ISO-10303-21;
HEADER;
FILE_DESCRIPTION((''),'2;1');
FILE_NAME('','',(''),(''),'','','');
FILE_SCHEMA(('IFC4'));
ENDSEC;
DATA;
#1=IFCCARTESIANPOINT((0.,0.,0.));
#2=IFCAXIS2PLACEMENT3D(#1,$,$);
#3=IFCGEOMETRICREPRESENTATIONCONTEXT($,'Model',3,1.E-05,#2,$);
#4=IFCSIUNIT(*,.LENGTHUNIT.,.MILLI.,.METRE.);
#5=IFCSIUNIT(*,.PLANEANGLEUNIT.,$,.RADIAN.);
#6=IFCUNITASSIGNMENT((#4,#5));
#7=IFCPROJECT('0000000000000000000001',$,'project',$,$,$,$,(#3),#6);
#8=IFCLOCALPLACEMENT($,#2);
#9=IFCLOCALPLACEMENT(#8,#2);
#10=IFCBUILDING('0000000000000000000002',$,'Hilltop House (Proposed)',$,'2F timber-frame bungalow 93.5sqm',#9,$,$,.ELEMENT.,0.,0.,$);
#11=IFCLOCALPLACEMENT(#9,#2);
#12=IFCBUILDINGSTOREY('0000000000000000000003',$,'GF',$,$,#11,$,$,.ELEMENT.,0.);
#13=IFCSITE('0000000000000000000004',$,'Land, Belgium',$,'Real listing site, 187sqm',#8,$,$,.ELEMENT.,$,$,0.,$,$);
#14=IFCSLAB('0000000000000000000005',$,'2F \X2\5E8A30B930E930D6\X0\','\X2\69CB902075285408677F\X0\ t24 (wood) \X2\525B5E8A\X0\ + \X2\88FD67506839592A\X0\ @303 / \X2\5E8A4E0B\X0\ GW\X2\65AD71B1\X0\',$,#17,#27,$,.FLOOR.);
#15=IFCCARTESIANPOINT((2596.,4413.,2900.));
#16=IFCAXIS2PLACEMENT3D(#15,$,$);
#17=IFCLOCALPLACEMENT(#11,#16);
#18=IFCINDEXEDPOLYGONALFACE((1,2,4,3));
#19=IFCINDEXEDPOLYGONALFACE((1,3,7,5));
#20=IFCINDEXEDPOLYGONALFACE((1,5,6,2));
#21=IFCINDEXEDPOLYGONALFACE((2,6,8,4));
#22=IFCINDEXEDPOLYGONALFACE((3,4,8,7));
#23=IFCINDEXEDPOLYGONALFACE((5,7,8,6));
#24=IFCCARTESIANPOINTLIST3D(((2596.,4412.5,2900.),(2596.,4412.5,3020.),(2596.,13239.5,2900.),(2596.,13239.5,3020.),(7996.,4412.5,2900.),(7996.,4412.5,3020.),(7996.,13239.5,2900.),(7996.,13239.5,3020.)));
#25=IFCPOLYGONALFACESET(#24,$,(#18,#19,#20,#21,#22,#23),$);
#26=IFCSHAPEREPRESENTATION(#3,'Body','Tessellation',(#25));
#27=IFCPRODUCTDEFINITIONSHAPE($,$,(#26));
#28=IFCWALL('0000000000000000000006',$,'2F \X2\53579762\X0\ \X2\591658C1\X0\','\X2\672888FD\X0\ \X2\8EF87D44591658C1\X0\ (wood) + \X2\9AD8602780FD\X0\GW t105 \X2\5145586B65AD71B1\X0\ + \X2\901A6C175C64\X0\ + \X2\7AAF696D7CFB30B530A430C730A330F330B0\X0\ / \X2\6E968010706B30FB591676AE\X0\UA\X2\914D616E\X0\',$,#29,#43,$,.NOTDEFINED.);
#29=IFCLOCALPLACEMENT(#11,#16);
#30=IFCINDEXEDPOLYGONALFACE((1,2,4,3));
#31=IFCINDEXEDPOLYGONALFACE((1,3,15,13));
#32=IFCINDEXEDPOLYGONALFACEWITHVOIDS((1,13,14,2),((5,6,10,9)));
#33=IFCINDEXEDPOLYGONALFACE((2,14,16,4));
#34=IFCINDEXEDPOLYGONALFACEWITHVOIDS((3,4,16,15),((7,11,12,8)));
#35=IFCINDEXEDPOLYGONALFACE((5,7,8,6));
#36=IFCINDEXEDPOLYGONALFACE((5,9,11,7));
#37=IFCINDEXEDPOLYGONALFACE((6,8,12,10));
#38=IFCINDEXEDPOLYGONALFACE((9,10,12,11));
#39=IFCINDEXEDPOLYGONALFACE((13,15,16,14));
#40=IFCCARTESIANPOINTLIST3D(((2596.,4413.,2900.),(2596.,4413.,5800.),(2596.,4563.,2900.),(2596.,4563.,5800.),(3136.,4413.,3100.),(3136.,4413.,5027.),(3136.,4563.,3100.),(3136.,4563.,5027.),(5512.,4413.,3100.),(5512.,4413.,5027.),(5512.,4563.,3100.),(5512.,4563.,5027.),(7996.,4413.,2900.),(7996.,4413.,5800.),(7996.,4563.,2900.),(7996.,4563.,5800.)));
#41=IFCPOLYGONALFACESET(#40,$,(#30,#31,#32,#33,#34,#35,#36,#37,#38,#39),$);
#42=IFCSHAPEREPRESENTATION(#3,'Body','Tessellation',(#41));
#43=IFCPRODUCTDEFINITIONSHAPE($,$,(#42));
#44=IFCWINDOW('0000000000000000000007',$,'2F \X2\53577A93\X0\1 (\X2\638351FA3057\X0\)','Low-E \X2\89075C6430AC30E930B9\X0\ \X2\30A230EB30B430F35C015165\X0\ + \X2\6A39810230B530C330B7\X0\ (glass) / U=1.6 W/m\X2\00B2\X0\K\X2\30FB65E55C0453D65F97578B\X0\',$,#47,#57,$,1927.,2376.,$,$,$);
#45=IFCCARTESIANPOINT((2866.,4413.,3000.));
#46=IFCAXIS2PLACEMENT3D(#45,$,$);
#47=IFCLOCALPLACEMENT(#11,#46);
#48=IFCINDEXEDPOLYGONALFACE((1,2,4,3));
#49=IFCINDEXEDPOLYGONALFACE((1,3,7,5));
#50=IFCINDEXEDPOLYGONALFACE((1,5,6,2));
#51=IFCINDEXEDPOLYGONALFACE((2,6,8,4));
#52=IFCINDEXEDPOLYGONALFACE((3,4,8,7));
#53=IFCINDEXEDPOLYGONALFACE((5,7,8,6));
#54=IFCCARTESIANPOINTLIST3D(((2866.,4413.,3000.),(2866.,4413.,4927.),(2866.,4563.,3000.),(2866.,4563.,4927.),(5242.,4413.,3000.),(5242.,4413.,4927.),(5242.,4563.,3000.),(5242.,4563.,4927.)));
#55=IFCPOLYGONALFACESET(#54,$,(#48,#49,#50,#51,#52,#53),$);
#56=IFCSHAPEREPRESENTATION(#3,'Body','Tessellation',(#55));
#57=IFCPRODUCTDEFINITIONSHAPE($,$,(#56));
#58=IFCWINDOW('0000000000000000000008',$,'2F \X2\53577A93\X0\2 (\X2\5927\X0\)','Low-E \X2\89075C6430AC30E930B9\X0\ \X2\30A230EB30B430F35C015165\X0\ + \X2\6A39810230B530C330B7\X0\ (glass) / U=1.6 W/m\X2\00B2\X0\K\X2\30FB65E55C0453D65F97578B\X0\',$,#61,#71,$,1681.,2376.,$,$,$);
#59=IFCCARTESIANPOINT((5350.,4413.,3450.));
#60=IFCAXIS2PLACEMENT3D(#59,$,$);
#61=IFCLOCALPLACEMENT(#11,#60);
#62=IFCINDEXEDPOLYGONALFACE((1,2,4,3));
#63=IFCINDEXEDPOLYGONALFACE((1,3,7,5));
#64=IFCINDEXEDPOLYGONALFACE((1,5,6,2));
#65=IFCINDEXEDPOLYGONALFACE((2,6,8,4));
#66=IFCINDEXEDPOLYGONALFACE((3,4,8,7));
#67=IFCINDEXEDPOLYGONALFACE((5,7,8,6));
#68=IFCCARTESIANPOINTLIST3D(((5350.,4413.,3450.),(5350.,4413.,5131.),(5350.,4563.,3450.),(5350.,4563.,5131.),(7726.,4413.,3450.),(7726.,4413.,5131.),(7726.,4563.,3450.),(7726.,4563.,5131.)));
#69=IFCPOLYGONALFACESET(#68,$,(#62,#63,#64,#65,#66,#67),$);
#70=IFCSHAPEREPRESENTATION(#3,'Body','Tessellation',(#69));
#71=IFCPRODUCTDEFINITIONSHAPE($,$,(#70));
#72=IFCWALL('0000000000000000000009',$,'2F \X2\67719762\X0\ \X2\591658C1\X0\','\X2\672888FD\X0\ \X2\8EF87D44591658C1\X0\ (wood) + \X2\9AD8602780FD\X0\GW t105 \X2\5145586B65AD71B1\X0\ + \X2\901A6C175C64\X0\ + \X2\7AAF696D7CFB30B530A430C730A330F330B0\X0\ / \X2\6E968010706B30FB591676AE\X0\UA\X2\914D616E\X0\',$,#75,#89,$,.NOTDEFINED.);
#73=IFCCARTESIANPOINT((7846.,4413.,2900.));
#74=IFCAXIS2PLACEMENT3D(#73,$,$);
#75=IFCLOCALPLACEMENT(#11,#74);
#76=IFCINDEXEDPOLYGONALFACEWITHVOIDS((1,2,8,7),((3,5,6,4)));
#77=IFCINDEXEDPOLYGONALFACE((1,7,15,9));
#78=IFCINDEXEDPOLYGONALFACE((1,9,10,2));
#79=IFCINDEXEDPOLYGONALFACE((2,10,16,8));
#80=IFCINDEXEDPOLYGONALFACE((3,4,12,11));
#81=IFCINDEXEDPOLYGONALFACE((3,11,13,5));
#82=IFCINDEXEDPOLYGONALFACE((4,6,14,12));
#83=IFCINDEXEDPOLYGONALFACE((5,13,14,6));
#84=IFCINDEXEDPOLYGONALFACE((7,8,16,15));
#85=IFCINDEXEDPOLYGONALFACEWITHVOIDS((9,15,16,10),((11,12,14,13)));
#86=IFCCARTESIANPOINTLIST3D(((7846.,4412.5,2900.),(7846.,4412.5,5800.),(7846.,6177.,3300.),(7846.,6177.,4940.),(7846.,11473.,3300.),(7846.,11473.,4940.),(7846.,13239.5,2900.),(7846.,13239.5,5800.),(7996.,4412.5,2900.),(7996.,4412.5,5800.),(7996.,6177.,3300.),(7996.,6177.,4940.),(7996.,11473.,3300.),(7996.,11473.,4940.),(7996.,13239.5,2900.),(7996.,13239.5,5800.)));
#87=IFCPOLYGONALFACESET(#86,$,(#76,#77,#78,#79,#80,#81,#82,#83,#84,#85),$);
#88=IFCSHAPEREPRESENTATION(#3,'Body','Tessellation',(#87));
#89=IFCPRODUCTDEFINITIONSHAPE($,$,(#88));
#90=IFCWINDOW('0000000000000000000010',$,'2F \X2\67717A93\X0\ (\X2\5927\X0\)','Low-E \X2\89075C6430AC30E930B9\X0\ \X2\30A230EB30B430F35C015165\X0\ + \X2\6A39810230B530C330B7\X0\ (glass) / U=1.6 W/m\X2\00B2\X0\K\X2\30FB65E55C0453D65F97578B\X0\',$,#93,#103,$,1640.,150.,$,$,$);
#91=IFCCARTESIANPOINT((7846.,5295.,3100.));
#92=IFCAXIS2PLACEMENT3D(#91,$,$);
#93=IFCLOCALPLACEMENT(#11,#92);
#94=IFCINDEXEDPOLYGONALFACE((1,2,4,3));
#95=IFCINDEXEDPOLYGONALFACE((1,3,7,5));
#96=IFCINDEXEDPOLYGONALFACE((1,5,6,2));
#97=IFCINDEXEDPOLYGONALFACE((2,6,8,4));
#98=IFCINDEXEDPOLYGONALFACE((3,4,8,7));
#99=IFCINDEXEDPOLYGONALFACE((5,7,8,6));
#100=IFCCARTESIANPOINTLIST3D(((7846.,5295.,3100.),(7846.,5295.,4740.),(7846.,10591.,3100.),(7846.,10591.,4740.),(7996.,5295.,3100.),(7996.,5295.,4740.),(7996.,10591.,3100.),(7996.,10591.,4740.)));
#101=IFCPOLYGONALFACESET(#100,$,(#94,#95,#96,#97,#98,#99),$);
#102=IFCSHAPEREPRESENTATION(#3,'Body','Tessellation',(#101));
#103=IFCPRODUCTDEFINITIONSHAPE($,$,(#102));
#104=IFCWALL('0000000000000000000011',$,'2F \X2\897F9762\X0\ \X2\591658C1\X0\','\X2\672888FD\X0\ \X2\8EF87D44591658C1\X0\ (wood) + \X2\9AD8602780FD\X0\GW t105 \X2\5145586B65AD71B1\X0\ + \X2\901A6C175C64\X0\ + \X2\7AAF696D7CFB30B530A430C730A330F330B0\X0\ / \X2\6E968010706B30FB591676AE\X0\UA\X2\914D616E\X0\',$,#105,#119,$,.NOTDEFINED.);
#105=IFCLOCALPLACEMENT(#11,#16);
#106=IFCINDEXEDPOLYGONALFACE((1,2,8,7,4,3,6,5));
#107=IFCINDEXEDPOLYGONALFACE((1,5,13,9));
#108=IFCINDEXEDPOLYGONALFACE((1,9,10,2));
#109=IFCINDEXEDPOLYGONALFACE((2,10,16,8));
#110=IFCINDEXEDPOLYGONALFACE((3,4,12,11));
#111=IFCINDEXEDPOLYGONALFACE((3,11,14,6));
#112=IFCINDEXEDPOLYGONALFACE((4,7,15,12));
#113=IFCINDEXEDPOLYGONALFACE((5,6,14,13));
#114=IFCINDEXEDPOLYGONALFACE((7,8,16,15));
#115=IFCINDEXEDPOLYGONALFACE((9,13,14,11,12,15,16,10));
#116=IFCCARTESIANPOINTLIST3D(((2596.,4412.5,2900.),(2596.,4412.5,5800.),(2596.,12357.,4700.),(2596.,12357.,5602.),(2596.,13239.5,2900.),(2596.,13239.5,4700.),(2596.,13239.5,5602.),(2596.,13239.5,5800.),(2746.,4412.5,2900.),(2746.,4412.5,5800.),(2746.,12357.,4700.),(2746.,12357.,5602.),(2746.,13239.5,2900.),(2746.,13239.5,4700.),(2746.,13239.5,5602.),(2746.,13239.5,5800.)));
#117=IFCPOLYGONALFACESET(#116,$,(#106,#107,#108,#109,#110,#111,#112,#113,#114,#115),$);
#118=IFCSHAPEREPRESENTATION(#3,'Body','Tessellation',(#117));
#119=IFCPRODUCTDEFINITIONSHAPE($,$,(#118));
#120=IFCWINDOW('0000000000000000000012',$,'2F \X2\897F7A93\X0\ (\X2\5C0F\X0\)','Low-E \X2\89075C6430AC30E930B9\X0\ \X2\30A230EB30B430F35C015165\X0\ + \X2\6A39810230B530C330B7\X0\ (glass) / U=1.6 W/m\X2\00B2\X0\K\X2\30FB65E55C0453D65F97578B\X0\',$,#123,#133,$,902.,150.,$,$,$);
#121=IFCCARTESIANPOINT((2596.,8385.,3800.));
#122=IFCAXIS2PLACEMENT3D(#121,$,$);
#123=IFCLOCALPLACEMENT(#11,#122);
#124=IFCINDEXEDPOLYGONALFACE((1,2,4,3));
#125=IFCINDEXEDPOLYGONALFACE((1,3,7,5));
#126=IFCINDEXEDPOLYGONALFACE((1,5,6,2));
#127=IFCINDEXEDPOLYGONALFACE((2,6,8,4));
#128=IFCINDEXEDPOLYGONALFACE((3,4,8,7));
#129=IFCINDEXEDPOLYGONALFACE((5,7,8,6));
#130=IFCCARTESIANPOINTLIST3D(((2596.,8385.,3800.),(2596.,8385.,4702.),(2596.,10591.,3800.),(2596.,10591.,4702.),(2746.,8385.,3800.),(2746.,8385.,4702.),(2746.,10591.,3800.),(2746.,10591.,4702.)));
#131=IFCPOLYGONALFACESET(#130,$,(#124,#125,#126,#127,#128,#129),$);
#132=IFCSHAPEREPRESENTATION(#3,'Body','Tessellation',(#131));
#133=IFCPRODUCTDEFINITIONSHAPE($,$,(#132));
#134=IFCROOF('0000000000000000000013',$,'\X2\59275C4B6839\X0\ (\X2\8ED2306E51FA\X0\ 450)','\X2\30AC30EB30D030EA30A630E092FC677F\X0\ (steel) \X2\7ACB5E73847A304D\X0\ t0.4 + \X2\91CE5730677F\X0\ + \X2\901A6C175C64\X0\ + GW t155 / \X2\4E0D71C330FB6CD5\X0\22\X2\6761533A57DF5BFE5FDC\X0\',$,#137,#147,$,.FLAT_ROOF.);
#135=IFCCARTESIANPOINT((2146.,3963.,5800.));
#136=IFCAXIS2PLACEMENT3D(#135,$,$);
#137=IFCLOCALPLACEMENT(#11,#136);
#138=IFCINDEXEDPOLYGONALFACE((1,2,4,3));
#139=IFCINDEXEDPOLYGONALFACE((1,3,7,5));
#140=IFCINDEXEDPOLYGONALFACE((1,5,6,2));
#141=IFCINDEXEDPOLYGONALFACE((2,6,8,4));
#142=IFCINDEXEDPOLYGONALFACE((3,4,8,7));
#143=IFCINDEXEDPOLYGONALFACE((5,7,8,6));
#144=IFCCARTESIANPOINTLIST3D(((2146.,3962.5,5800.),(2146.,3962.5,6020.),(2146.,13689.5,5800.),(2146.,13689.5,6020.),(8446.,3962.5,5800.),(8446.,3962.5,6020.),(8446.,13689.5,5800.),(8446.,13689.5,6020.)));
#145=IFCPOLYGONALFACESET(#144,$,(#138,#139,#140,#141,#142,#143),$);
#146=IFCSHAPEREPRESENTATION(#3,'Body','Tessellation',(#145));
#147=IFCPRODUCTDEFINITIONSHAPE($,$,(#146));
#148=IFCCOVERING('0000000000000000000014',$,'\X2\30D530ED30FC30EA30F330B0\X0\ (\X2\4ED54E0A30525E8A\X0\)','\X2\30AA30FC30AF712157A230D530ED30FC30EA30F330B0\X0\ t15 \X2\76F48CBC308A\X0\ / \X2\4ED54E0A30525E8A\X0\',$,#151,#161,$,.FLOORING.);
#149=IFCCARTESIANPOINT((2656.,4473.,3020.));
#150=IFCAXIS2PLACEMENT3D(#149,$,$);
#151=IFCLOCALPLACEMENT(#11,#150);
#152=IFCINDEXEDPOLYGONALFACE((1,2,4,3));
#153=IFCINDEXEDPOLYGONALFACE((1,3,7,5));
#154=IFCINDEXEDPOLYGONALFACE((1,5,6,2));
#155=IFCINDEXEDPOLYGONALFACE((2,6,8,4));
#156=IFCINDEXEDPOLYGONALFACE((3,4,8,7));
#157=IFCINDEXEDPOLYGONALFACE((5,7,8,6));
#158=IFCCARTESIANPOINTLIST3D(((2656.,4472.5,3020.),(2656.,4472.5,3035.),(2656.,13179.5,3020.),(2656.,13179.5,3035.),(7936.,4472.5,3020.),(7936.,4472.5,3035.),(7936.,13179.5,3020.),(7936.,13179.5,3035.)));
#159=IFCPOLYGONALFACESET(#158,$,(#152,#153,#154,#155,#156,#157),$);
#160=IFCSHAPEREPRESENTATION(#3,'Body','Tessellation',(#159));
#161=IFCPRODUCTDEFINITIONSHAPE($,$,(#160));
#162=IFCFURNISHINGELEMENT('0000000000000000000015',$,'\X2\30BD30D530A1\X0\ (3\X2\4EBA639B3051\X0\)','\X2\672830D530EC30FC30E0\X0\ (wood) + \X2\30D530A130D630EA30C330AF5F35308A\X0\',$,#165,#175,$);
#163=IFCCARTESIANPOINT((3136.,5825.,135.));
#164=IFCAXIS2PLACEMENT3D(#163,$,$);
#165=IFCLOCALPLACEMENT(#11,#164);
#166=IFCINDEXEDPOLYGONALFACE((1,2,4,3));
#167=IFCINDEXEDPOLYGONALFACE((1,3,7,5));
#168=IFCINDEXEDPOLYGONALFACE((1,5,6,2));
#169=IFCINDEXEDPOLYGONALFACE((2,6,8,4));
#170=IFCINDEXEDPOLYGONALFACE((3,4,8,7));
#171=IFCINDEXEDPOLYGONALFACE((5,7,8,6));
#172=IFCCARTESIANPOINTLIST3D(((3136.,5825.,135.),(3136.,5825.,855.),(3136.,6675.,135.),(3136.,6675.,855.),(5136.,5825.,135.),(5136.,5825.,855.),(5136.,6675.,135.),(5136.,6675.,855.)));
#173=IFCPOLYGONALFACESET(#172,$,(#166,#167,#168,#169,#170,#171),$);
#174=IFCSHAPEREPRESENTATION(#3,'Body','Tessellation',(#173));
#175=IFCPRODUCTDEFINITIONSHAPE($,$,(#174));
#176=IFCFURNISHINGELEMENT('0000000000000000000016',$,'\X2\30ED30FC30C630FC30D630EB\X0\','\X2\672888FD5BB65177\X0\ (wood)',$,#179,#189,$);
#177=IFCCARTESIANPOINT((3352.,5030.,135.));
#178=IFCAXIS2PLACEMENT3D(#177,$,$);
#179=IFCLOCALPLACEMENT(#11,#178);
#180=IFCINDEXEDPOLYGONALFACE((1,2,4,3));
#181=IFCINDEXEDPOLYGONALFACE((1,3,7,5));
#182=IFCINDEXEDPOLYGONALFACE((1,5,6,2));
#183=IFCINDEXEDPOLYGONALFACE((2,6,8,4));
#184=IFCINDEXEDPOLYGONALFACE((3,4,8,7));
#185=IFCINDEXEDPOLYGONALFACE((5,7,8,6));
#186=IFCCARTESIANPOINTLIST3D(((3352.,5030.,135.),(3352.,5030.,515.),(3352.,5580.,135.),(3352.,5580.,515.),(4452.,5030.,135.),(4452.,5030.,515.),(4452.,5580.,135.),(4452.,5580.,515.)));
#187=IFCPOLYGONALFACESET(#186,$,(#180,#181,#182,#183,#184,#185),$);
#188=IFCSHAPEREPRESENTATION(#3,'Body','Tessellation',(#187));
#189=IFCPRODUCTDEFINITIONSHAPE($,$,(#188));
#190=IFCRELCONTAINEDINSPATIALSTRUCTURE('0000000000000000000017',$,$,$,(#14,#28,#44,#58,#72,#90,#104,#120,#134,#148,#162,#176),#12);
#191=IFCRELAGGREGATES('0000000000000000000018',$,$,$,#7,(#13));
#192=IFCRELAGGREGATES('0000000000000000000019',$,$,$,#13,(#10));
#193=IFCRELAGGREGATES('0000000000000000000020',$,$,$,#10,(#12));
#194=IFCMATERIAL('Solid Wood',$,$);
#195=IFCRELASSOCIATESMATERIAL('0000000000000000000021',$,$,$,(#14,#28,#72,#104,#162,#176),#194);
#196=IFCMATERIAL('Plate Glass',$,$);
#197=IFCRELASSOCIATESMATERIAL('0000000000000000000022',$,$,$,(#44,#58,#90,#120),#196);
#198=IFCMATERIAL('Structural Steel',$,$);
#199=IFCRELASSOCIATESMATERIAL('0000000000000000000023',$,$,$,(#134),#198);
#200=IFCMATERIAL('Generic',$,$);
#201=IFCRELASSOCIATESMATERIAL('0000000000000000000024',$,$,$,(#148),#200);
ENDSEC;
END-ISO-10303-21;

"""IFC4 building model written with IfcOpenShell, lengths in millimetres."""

from ifc_helpers import new_model, si_unit, frame, frame_2d, origin, place, context, project, spatial, rectangle, extrude, material, element, fill, save


model = new_model("IFC4")

# Units and contexts
model_context = context("Model", 3, precision=1e-05, world=origin())
ifc_project = project(units=[si_unit("LENGTHUNIT", "METRE", prefix="MILLI"), si_unit("PLANEANGLEUNIT", "RADIAN")], contexts=[model_context])

# Site, building, storey
site_placement = place(None, origin())
site = spatial("IfcSite", under=ifc_project, at=site_placement, Name="Land, Belgium", ObjectType="Real listing site, 187sqm", CompositionType="ELEMENT", RefElevation=0.0)
building_placement = place(site_placement, origin())
building = spatial("IfcBuilding", under=site, at=building_placement, Name="Hilltop House (Proposed)", ObjectType="2F timber-frame bungalow 93.5sqm", CompositionType="ELEMENT", ElevationOfRefHeight=0.0, ElevationOfTerrain=0.0)
storey_placement = place(building_placement, origin())
storey = spatial("IfcBuildingStorey", under=building, at=storey_placement, Name="GF", CompositionType="ELEMENT", Elevation=0.0)

# Slab
ifc_material_1 = material(Name="Solid Wood")
slab_placement = place(storey_placement, frame((2596.0, 4413.0, 2900.0)))
element("IfcSlab", 1, at=slab_placement, inside=storey, material=ifc_material_1, Name="2F 床スラブ", Description="構造用合板 t24 (wood) 剛床 + 製材根太 @303 / 床下 GW断熱", PredefinedType="FLOOR", context=model_context, shape_type="SweptSolid", body=[
    extrude(rectangle(XDim=5400.0, YDim=8827.0, at=frame_2d((2700.0, 4413.0))), frame((2596.0, 4413.0, 2900.0)), (0.0, 0.0, 1.0), 120.0),
])

# Wall, openings, windows
wall_1_placement = place(storey_placement, frame((2596.0, 4413.0, 2900.0)))
wall_1 = element("IfcWall", 2, at=wall_1_placement, inside=storey, material=ifc_material_1, Name="2F 南面 外壁", Description="木製 軸組外壁 (wood) + 高性能GW t105 充填断熱 + 通気層 + 窯業系サイディング / 準耐火・外皮UA配慮", PredefinedType="NOTDEFINED", context=model_context, shape_type="SweptSolid", body=[
    extrude(rectangle(XDim=5400.0, YDim=150.0, at=frame_2d((2700.0, 75.0))), frame((2596.0, 4413.0, 2900.0)), (0.0, 0.0, 1.0), 2900.0),
])
opening_1_placement = place(storey_placement, frame((2866.0, 4413.0, 3000.0)))
opening_1 = element("IfcOpeningElement", 3, at=opening_1_placement, cuts=wall_1, PredefinedType="NOTDEFINED", context=model_context, shape_type="SweptSolid", body=[
    extrude(rectangle(XDim=2376.0, YDim=150.0, at=frame_2d((1188.0, 75.0))), frame((2866.0, 4413.0, 3000.0)), (0.0, 0.0, 1.0), 1927.0),
])
opening_2_placement = place(storey_placement, frame((5350.0, 4413.0, 3450.0)))
opening_2 = element("IfcOpeningElement", 4, at=opening_2_placement, cuts=wall_1, PredefinedType="NOTDEFINED", context=model_context, shape_type="SweptSolid", body=[
    extrude(rectangle(XDim=2376.0, YDim=150.0, at=frame_2d((1188.0, 75.0))), frame((5350.0, 4413.0, 3450.0)), (0.0, 0.0, 1.0), 1681.0),
])
ifc_material_2 = material(Name="Plate Glass")
window_1_placement = place(storey_placement, frame((2866.0, 4413.0, 3000.0)))
window_1 = element("IfcWindow", 5, at=window_1_placement, inside=storey, material=ifc_material_2, Name="2F 南窓1 (掃出し)", Description="Low-E 複層ガラス アルゴン封入 + 樹脂サッシ (glass) / U=1.6 W/m²K・日射取得型", OverallHeight=1927.0, OverallWidth=2376.0, context=model_context, shape_type="SweptSolid", body=[
    extrude(rectangle(XDim=2376.0, YDim=150.0, at=frame_2d((1188.0, 75.0))), frame((2866.0, 4413.0, 3000.0)), (0.0, 0.0, 1.0), 1927.0),
])
fill(opening_1, window_1)
window_2_placement = place(storey_placement, frame((5350.0, 4413.0, 3450.0)))
window_2 = element("IfcWindow", 6, at=window_2_placement, inside=storey, material=ifc_material_2, Name="2F 南窓2 (大)", Description="Low-E 複層ガラス アルゴン封入 + 樹脂サッシ (glass) / U=1.6 W/m²K・日射取得型", OverallHeight=1681.0, OverallWidth=2376.0, context=model_context, shape_type="SweptSolid", body=[
    extrude(rectangle(XDim=2376.0, YDim=150.0, at=frame_2d((1188.0, 75.0))), frame((5350.0, 4413.0, 3450.0)), (0.0, 0.0, 1.0), 1681.0),
])
fill(opening_2, window_2)

# Walls, openings, windows
wall_2_placement = place(storey_placement, frame((7846.0, 4413.0, 2900.0)))
wall_2 = element("IfcWall", 7, at=wall_2_placement, inside=storey, material=ifc_material_1, Name="2F 東面 外壁", Description="木製 軸組外壁 (wood) + 高性能GW t105 充填断熱 + 通気層 + 窯業系サイディング / 準耐火・外皮UA配慮", PredefinedType="NOTDEFINED", context=model_context, shape_type="SweptSolid", body=[
    extrude(rectangle(XDim=150.0, YDim=8827.0, at=frame_2d((75.0, 4413.0))), frame((7846.0, 4413.0, 2900.0)), (0.0, 0.0, 1.0), 2900.0),
])
opening_3_placement = place(storey_placement, frame((7846.0, 5295.0, 3100.0)))
opening_3 = element("IfcOpeningElement", 8, at=opening_3_placement, cuts=wall_2, PredefinedType="NOTDEFINED", context=model_context, shape_type="SweptSolid", body=[
    extrude(rectangle(XDim=150.0, YDim=5296.0, at=frame_2d((75.0, 2648.0))), frame((7846.0, 5295.0, 3100.0)), (0.0, 0.0, 1.0), 1640.0),
])
window_3_placement = place(storey_placement, frame((7846.0, 5295.0, 3100.0)))
window_3 = element("IfcWindow", 9, at=window_3_placement, inside=storey, material=ifc_material_2, Name="2F 東窓 (大)", Description="Low-E 複層ガラス アルゴン封入 + 樹脂サッシ (glass) / U=1.6 W/m²K・日射取得型", OverallHeight=1640.0, OverallWidth=150.0, context=model_context, shape_type="SweptSolid", body=[
    extrude(rectangle(XDim=150.0, YDim=5296.0, at=frame_2d((75.0, 2648.0))), frame((7846.0, 5295.0, 3100.0)), (0.0, 0.0, 1.0), 1640.0),
])
fill(opening_3, window_3)
wall_3_placement = place(storey_placement, frame((2596.0, 4413.0, 2900.0)))
wall_3 = element("IfcWall", 10, at=wall_3_placement, inside=storey, material=ifc_material_1, Name="2F 西面 外壁", Description="木製 軸組外壁 (wood) + 高性能GW t105 充填断熱 + 通気層 + 窯業系サイディング / 準耐火・外皮UA配慮", PredefinedType="NOTDEFINED", context=model_context, shape_type="SweptSolid", body=[
    extrude(rectangle(XDim=150.0, YDim=8827.0, at=frame_2d((75.0, 4413.0))), frame((2596.0, 4413.0, 2900.0)), (0.0, 0.0, 1.0), 2900.0),
])
opening_4_placement = place(storey_placement, frame((2596.0, 8385.0, 3800.0)))
opening_4 = element("IfcOpeningElement", 11, at=opening_4_placement, cuts=wall_3, PredefinedType="NOTDEFINED", context=model_context, shape_type="SweptSolid", body=[
    extrude(rectangle(XDim=150.0, YDim=2206.0, at=frame_2d((75.0, 1103.0))), frame((2596.0, 8385.0, 3800.0)), (0.0, 0.0, 1.0), 902.0),
])
window_4_placement = place(storey_placement, frame((2596.0, 8385.0, 3800.0)))
window_4 = element("IfcWindow", 12, at=window_4_placement, inside=storey, material=ifc_material_2, Name="2F 西窓 (小)", Description="Low-E 複層ガラス アルゴン封入 + 樹脂サッシ (glass) / U=1.6 W/m²K・日射取得型", OverallHeight=902.0, OverallWidth=150.0, context=model_context, shape_type="SweptSolid", body=[
    extrude(rectangle(XDim=150.0, YDim=2206.0, at=frame_2d((75.0, 1103.0))), frame((2596.0, 8385.0, 3800.0)), (0.0, 0.0, 1.0), 902.0),
])
fill(opening_4, window_4)

# Roof
ifc_material_3 = material(Name="Structural Steel")
roof_placement = place(storey_placement, frame((2146.0, 3963.0, 5800.0)))
element("IfcRoof", 13, at=roof_placement, inside=storey, material=ifc_material_3, Name="大屋根 (軒の出 450)", Description="ガルバリウム鋼板 (steel) 立平葺き t0.4 + 野地板 + 通気層 + GW t155 / 不燃・法22条区域対応", PredefinedType="FLAT_ROOF", context=model_context, shape_type="SweptSolid", body=[
    extrude(rectangle(XDim=6300.0, YDim=9727.0, at=frame_2d((3150.0, 4863.0))), frame((2146.0, 3963.0, 5800.0)), (0.0, 0.0, 1.0), 220.0),
])

# Covering
ifc_material_4 = material(Name="Generic")
covering_placement = place(storey_placement, frame((2656.0, 4473.0, 3020.0)))
element("IfcCovering", 14, at=covering_placement, inside=storey, material=ifc_material_4, Name="フローリング (仕上げ床)", Description="オーク無垢フローリング t15 直貼り / 仕上げ床", PredefinedType="FLOORING", context=model_context, shape_type="SweptSolid", body=[
    extrude(rectangle(XDim=5280.0, YDim=8707.0, at=frame_2d((2640.0, 4353.0))), frame((2656.0, 4473.0, 3020.0)), (0.0, 0.0, 1.0), 15.0),
])

# Furnishing elements
furnishing_1_placement = place(storey_placement, frame((3136.0, 5825.0, 135.0)))
element("IfcFurnishingElement", 15, at=furnishing_1_placement, inside=storey, material=ifc_material_1, Name="ソファ (3人掛け)", Description="木フレーム (wood) + ファブリック張り", context=model_context, shape_type="SweptSolid", body=[
    extrude(rectangle(XDim=2000.0, YDim=850.0, at=frame_2d((1000.0, 425.0))), frame((3136.0, 5825.0, 135.0)), (0.0, 0.0, 1.0), 720.0),
])
furnishing_2_placement = place(storey_placement, frame((3352.0, 5030.0, 135.0)))
element("IfcFurnishingElement", 16, at=furnishing_2_placement, inside=storey, material=ifc_material_1, Name="ローテーブル", Description="木製家具 (wood)", context=model_context, shape_type="SweptSolid", body=[
    extrude(rectangle(XDim=1100.0, YDim=550.0, at=frame_2d((550.0, 275.0))), frame((3352.0, 5030.0, 135.0)), (0.0, 0.0, 1.0), 380.0),
])

save(model, "model.ifc")
